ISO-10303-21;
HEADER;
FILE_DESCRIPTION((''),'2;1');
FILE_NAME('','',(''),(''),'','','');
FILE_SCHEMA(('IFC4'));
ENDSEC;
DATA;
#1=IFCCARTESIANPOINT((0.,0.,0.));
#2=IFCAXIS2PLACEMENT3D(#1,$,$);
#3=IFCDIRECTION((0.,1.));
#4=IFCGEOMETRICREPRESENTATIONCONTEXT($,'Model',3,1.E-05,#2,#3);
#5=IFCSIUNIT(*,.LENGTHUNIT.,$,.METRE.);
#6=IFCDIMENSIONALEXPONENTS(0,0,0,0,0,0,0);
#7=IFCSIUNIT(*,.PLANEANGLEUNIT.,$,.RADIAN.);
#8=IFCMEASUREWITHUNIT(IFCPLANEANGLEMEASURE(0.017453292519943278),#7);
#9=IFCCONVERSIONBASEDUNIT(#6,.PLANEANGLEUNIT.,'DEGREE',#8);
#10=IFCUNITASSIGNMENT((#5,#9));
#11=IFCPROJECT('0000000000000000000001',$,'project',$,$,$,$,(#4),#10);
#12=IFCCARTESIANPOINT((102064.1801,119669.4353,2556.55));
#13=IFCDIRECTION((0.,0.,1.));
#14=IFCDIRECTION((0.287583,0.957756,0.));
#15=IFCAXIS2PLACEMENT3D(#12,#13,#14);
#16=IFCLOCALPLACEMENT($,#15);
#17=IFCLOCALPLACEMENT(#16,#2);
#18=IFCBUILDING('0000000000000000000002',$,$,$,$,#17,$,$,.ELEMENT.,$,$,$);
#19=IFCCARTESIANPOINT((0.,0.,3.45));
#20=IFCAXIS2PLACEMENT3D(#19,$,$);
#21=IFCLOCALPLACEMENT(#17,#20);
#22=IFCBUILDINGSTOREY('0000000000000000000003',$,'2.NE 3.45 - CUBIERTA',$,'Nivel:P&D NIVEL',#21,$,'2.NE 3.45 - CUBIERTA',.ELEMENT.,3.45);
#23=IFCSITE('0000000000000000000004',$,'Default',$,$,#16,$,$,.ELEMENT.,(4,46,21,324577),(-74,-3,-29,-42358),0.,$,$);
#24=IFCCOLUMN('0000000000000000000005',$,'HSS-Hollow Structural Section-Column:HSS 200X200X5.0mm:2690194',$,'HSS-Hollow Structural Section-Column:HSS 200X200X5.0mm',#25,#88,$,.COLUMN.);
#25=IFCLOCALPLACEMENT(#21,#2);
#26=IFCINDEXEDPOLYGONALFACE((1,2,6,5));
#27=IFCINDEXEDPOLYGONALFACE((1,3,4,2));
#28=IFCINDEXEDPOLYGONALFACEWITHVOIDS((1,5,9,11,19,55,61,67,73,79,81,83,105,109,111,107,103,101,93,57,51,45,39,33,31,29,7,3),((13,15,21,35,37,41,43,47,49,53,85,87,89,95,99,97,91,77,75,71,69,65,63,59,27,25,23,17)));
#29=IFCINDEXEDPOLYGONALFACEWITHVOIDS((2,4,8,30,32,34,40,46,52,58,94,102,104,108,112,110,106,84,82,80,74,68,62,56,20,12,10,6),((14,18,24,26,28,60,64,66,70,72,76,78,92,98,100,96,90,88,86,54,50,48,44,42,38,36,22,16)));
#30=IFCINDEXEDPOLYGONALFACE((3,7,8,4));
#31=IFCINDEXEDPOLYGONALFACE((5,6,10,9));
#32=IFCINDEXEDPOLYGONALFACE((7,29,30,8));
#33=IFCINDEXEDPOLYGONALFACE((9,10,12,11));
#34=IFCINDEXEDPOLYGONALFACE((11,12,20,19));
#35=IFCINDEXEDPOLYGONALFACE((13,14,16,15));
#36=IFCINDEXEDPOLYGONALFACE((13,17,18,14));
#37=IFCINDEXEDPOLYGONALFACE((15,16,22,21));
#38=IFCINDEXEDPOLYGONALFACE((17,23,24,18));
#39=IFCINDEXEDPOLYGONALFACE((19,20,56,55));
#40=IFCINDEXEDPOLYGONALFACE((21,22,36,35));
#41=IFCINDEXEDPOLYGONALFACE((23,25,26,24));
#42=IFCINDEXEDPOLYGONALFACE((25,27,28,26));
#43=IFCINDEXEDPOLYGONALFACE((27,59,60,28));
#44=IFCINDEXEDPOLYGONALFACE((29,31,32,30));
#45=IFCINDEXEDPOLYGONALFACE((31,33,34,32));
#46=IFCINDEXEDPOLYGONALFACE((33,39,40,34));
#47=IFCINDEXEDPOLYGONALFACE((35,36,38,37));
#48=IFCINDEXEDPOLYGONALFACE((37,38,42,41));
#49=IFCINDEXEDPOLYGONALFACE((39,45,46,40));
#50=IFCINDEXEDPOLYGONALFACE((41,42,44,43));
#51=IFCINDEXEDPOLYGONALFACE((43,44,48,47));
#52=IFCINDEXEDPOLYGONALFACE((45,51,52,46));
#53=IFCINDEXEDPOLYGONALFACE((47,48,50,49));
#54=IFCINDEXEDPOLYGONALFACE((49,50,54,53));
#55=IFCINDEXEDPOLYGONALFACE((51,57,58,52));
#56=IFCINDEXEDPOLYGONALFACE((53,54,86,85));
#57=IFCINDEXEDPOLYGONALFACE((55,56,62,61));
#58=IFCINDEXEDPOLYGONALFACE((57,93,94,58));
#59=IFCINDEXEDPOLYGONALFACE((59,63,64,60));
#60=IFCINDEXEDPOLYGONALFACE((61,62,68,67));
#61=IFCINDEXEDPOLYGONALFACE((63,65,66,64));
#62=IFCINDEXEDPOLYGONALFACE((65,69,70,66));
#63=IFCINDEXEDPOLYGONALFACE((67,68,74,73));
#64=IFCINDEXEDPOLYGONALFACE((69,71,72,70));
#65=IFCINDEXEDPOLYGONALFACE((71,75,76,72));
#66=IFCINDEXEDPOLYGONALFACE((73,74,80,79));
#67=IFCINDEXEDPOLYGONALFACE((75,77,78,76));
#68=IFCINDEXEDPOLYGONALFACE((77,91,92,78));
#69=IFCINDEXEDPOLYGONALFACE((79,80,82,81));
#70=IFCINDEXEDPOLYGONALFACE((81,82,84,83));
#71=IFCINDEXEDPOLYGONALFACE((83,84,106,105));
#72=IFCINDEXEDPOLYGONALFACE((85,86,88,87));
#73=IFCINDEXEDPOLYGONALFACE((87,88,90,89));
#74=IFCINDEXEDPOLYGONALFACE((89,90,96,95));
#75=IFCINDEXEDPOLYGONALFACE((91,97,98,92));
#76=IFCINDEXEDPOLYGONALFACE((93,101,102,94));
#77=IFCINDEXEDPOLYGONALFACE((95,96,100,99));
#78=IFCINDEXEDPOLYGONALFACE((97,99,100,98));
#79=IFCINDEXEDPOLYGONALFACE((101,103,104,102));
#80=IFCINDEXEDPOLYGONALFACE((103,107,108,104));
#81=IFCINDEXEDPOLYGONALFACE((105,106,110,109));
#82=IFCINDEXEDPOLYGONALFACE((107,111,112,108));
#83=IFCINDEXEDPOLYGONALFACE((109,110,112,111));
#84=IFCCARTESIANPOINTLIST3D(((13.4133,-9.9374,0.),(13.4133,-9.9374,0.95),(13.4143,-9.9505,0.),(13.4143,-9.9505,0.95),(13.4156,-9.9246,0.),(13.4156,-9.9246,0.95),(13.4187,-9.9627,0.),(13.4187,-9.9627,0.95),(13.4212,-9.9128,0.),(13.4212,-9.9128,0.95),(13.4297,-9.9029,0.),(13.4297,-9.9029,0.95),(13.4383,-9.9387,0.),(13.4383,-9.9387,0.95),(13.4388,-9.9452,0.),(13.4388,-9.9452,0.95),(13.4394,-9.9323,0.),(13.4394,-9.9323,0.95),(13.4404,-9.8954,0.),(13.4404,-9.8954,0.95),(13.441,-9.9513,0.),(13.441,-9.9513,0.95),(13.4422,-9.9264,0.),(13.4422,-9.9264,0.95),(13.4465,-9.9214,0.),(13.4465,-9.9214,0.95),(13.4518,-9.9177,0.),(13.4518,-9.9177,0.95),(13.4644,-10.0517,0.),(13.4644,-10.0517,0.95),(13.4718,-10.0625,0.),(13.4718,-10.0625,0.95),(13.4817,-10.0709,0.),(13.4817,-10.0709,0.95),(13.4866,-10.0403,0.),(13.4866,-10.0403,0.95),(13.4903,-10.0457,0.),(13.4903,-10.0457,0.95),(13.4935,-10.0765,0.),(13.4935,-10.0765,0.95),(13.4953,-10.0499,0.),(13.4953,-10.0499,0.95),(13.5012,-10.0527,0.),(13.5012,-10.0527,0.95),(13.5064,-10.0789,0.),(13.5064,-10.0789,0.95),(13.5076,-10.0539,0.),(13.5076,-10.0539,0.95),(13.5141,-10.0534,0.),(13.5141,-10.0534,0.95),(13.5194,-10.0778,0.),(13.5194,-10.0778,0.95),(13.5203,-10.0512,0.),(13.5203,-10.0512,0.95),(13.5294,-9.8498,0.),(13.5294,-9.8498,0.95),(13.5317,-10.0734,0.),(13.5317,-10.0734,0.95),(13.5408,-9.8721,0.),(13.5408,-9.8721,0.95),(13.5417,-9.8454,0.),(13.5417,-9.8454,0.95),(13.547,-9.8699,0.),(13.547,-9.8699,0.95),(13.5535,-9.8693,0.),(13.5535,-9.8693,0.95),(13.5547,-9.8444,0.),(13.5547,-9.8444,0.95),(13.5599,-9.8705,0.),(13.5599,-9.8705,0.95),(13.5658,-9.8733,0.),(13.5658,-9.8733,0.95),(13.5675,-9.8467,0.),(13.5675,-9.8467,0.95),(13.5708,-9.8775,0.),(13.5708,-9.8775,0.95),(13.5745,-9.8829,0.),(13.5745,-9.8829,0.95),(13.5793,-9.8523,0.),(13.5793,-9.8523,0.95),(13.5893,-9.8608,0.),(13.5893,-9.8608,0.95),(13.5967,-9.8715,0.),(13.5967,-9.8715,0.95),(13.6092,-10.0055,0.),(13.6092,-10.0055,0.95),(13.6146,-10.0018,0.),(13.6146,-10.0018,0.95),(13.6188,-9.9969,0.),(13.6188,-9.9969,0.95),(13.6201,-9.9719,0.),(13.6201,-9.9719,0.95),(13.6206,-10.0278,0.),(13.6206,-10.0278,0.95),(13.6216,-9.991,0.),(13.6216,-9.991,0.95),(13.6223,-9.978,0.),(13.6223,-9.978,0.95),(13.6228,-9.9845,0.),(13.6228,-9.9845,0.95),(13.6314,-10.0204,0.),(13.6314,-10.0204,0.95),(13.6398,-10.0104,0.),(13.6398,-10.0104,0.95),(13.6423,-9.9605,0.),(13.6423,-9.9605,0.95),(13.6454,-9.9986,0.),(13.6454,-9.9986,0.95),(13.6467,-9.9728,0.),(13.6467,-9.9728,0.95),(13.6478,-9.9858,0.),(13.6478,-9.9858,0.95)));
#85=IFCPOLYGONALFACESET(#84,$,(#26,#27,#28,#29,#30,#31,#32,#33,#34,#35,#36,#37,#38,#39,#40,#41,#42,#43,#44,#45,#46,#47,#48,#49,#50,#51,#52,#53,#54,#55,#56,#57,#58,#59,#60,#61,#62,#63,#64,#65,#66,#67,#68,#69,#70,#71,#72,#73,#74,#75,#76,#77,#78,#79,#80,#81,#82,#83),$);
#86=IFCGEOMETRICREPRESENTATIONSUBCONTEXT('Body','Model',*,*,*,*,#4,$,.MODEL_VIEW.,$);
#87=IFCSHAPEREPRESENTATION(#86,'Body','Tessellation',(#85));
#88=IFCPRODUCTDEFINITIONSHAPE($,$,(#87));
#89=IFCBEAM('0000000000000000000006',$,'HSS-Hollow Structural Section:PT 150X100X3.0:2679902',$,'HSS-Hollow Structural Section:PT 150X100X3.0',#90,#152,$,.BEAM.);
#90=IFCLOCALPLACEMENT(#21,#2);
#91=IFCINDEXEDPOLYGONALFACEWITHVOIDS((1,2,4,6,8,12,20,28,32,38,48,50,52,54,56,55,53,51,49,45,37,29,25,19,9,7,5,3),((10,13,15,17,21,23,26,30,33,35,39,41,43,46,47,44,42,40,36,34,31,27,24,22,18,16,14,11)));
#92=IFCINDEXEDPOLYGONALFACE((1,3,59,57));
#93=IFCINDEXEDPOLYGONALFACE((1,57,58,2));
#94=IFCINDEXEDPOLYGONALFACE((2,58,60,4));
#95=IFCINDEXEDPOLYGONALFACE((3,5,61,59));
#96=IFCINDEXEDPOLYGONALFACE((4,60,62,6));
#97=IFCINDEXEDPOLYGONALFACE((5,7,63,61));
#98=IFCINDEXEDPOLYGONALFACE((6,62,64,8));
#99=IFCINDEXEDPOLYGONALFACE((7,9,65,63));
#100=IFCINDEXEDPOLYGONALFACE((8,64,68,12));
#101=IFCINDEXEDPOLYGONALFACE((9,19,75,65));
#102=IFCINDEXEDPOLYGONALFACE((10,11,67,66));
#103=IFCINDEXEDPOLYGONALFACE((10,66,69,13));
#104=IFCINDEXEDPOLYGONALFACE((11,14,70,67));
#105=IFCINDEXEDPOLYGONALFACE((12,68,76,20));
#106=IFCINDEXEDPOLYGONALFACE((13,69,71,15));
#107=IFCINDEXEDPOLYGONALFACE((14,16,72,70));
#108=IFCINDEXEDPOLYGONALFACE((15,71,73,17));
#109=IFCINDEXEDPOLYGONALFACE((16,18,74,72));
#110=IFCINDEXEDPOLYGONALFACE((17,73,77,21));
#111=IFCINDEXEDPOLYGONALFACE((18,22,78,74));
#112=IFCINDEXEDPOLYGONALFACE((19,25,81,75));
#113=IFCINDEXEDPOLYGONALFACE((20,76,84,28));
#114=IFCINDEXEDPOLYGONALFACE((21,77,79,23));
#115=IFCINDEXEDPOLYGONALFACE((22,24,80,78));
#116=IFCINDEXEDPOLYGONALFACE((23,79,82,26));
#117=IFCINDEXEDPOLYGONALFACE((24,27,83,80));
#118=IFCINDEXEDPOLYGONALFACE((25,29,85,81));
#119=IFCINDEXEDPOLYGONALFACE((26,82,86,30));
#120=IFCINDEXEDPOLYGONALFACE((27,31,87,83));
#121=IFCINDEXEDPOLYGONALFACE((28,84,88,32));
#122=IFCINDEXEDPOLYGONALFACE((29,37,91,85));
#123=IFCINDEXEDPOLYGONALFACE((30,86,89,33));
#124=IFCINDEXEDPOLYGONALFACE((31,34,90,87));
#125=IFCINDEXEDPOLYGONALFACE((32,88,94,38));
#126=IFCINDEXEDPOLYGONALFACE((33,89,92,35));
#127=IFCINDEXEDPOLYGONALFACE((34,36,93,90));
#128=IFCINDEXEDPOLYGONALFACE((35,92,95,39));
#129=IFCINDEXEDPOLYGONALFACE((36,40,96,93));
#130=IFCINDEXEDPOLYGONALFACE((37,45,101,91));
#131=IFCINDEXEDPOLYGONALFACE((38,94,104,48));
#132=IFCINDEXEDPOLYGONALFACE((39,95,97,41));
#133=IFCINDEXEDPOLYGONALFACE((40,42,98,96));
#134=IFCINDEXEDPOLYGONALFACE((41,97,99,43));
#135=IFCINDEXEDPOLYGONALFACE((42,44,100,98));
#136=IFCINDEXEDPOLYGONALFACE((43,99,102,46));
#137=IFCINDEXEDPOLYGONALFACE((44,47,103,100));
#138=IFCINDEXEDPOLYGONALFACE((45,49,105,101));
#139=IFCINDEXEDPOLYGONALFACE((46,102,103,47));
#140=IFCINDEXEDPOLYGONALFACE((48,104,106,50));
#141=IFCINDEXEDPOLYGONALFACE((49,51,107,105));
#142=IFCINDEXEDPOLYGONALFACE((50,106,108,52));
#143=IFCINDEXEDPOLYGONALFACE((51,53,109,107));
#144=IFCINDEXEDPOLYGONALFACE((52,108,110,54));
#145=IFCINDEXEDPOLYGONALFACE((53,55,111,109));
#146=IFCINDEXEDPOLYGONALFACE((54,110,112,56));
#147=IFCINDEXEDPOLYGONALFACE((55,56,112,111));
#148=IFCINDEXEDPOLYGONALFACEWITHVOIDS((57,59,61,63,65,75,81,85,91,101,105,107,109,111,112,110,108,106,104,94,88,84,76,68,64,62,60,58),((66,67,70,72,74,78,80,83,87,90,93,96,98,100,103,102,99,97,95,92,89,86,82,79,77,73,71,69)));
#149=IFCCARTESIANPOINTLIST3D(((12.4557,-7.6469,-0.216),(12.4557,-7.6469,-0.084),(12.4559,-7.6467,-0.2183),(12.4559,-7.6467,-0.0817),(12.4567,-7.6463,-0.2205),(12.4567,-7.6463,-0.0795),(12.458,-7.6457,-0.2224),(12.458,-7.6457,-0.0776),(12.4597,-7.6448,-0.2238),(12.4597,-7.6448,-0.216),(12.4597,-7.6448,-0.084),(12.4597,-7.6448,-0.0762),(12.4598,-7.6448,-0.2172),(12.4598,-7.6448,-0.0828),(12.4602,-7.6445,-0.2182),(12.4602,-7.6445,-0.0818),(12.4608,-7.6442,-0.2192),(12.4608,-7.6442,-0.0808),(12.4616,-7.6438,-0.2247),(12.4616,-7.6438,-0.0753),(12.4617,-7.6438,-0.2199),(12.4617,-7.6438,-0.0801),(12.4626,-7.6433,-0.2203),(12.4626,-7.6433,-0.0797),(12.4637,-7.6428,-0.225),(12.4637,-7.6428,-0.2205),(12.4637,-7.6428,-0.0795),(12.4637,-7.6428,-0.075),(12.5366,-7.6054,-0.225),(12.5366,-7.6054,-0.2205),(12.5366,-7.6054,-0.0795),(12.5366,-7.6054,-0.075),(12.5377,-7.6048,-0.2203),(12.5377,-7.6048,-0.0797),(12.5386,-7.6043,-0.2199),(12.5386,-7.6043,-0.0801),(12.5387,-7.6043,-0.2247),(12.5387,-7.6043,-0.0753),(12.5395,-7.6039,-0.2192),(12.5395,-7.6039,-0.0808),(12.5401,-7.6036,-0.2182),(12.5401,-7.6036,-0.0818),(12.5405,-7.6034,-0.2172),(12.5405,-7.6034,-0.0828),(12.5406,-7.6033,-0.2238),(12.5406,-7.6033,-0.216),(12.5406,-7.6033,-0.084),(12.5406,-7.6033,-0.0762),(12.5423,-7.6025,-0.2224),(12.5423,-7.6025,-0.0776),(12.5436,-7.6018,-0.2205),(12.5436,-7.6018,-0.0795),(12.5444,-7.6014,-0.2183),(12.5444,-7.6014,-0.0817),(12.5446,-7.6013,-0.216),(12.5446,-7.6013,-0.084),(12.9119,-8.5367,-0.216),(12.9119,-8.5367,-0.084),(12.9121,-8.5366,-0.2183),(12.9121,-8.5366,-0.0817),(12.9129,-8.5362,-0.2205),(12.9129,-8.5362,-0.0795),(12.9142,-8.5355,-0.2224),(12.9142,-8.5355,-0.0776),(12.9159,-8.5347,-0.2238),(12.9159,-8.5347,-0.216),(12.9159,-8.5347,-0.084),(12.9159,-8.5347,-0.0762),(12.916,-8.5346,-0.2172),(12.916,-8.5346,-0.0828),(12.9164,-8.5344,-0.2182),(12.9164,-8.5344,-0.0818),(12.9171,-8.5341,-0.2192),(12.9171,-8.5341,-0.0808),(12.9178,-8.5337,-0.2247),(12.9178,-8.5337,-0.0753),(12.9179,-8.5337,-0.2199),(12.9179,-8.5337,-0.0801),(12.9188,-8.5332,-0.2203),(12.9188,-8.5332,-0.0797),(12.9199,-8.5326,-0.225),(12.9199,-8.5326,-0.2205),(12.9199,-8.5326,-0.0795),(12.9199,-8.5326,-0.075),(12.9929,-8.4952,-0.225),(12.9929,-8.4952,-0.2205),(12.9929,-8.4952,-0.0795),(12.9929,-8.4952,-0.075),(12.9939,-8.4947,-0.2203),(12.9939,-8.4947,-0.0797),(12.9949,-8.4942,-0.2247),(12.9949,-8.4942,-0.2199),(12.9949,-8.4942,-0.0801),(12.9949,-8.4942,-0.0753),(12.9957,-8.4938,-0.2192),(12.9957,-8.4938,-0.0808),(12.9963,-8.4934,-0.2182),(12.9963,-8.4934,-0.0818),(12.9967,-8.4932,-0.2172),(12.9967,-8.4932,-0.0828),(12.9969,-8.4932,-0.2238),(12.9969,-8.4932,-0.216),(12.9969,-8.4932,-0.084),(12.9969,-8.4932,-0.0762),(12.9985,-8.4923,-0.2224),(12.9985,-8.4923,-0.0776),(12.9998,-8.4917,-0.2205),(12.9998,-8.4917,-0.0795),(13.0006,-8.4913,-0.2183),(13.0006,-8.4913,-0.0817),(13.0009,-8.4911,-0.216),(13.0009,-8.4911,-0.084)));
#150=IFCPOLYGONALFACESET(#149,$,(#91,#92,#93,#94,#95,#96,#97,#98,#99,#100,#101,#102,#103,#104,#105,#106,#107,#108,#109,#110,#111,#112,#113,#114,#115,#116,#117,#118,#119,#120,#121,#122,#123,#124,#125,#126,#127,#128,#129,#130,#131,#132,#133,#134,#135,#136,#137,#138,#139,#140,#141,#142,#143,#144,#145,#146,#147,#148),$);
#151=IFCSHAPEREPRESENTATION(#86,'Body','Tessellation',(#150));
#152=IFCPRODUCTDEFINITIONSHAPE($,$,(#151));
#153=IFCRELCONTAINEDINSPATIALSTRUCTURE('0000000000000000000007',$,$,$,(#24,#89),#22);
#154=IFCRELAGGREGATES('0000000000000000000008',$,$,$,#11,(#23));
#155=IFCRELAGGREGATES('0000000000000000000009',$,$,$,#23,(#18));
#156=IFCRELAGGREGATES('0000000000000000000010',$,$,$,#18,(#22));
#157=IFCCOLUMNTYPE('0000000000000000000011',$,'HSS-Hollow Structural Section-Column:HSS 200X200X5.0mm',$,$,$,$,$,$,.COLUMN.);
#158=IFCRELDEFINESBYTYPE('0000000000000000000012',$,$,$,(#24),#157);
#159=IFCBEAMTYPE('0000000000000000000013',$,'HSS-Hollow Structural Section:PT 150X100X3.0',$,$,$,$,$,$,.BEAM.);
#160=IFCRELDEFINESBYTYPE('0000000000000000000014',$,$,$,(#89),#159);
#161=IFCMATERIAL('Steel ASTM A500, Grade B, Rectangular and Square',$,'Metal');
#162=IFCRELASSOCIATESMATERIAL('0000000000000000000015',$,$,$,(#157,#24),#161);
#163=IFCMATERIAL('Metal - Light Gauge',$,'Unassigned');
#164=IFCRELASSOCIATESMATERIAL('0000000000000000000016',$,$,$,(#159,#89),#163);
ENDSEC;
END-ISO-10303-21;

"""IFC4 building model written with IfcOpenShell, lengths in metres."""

from ifc_helpers import new_model, entity, si_unit, converted_unit, direction, frame, origin, place, context, subcontext, project, spatial, line, arc, indexed_curve, outline, extrude, source, transform, mapped, material, type_object, type_shapes, element, save


model = new_model("IFC4")

# Units and contexts
model_context = context("Model", 3, precision=1e-05, world=origin(), true_north=direction((0.0, 1.0)))
body_context = subcontext(model_context, "Body", "Model", "MODEL_VIEW")
ifc_project = project(units=[si_unit("LENGTHUNIT", "METRE"), converted_unit("PLANEANGLEUNIT", "DEGREE", entity("IfcPlaneAngleMeasure", 0.017453292519943278), si_unit("PLANEANGLEUNIT", "RADIAN"), dimensions=[0, 0, 0, 0, 0, 0, 0])], contexts=[model_context])

# Site, building, storey
site_placement = place(None, frame((102064.1801, 119669.4353, 2556.55), z_axis=(0.0, 0.0, 1.0), x_axis=(0.287583, 0.957756, 0.0)))
site = spatial("IfcSite", under=ifc_project, at=site_placement, Name="Default", CompositionType="ELEMENT", RefLatitude=(4, 46, 21, 324577), RefLongitude=(-74, -3, -29, -42358), RefElevation=0.0)
building_placement = place(site_placement, origin())
building = spatial("IfcBuilding", under=site, at=building_placement, CompositionType="ELEMENT")
storey_placement = place(building_placement, frame((0.0, 0.0, 3.45)))
storey = spatial("IfcBuildingStorey", under=building, at=storey_placement, Name="2.NE 3.45 - CUBIERTA", ObjectType="Nivel:P&D NIVEL", LongName="2.NE 3.45 - CUBIERTA", CompositionType="ELEMENT", Elevation=3.45)

# Column
ifc_material_1 = material(Name="Steel ASTM A500, Grade B, Rectangular and Square", Category="Metal")
column_type = type_object("IfcColumnType", Name="HSS-Hollow Structural Section-Column:HSS 200X200X5.0mm", PredefinedType="COLUMN", material=ifc_material_1)
shared_shape_1 = source(origin(), body_context, "Body", "SweptSolid", [
    extrude(outline(indexed_curve([(-0.05, -0.1), (0.05, -0.1), (0.0854, -0.0854), (0.1, -0.05), (0.1, 0.05), (0.0854, 0.0854), (0.05, 0.1), (-0.05, 0.1), (-0.0854, 0.0854), (-0.1, 0.05), (-0.1, -0.05), (-0.0854, -0.0854)], segments=[line(1, 2), arc(2, 3, 4), line(4, 5), arc(5, 6, 7), line(7, 8), arc(8, 9, 10), line(10, 11), arc(11, 12, 1)], self_intersect=False), holes=[indexed_curve([(-0.05, -0.075), (-0.0677, -0.0677), (-0.075, -0.05), (-0.075, 0.05), (-0.0677, 0.0677), (-0.05, 0.075), (0.05, 0.075), (0.0677, 0.0677), (0.075, 0.05), (0.075, -0.05), (0.0677, -0.0677), (0.05, -0.075)], segments=[arc(1, 2, 3), line(3, 4), arc(4, 5, 6), line(6, 7), arc(7, 8, 9), line(9, 10), arc(10, 11, 12), line(12, 1)], self_intersect=False)]), frame((0.0, 0.0, 3.45), z_axis=(0.0, 0.0, 1.0), x_axis=(-1.0, 0.0, 0.0)), (0.0, 0.0, 1.0), 0.95),
])
type_shapes(column_type, [shared_shape_1])
column_placement = place(storey_placement, frame((13.5305, -9.9616, -3.45), z_axis=(0.0, 0.0, 1.0), x_axis=(0.889869, 0.456217, 0.0)))
element("IfcColumn", 1, at=column_placement, inside=storey, type_object=column_type, material=ifc_material_1, Name="HSS-Hollow Structural Section-Column:HSS 200X200X5.0mm:2690194", ObjectType="HSS-Hollow Structural Section-Column:HSS 200X200X5.0mm", PredefinedType="COLUMN", context=body_context, shape_type="MappedRepresentation", body=[
    mapped(shared_shape_1, transform((0.0, 0.0, 0.0), scale=1.0)),
])

# Beam
ifc_material_2 = material(Name="Metal - Light Gauge", Category="Unassigned")
beam_type_1 = type_object("IfcBeamType", Name="HSS-Hollow Structural Section:PT 150X100X3.0", PredefinedType="BEAM", material=ifc_material_2)
shared_shape_2 = source(origin(), body_context, "Body", "SweptSolid", [
    extrude(outline(indexed_curve([(-0.05, -0.066), (-0.0474, -0.0724), (-0.041, -0.075), (0.041, -0.075), (0.0474, -0.0724), (0.05, -0.066), (0.05, 0.066), (0.0474, 0.0724), (0.041, 0.075), (-0.041, 0.075), (-0.0474, 0.0724), (-0.05, 0.066)], segments=[arc(1, 2, 3), line(3, 4), arc(4, 5, 6), line(6, 7), arc(7, 8, 9), line(9, 10), arc(10, 11, 12), line(12, 1)], self_intersect=False), holes=[indexed_curve([(0.041, -0.0705), (-0.041, -0.0705), (-0.0442, -0.0692), (-0.0455, -0.066), (-0.0455, 0.066), (-0.0442, 0.0692), (-0.041, 0.0705), (0.041, 0.0705), (0.0442, 0.0692), (0.0455, 0.066), (0.0455, -0.066), (0.0442, -0.0692)], segments=[line(1, 2), arc(2, 3, 4), line(4, 5), arc(5, 6, 7), line(7, 8), arc(8, 9, 10), line(10, 11), arc(11, 12, 1)], self_intersect=False)]), frame((-0.5, 0.0, 0.0), z_axis=(1.0, 0.0, 0.0), x_axis=(0.0, -1.0, 0.0)), (0.0, 0.0, 1.0), 1.0),
])
type_shapes(beam_type_1, [shared_shape_2])
beam_1_placement = place(storey_placement, frame((12.7283, -8.069, -0.15), z_axis=(0.0, 0.0, 1.0), x_axis=(-0.456217, 0.889869, 0.0)))
element("IfcBeam", 2, at=beam_1_placement, inside=storey, type_object=beam_type_1, material=ifc_material_2, Name="HSS-Hollow Structural Section:PT 150X100X3.0:2679902", ObjectType="HSS-Hollow Structural Section:PT 150X100X3.0", PredefinedType="BEAM", context=body_context, shape_type="MappedRepresentation", body=[
    mapped(shared_shape_2, transform((0.0, 0.0, 0.0), scale=1.0)),
])

save(model, "model.ifc")
